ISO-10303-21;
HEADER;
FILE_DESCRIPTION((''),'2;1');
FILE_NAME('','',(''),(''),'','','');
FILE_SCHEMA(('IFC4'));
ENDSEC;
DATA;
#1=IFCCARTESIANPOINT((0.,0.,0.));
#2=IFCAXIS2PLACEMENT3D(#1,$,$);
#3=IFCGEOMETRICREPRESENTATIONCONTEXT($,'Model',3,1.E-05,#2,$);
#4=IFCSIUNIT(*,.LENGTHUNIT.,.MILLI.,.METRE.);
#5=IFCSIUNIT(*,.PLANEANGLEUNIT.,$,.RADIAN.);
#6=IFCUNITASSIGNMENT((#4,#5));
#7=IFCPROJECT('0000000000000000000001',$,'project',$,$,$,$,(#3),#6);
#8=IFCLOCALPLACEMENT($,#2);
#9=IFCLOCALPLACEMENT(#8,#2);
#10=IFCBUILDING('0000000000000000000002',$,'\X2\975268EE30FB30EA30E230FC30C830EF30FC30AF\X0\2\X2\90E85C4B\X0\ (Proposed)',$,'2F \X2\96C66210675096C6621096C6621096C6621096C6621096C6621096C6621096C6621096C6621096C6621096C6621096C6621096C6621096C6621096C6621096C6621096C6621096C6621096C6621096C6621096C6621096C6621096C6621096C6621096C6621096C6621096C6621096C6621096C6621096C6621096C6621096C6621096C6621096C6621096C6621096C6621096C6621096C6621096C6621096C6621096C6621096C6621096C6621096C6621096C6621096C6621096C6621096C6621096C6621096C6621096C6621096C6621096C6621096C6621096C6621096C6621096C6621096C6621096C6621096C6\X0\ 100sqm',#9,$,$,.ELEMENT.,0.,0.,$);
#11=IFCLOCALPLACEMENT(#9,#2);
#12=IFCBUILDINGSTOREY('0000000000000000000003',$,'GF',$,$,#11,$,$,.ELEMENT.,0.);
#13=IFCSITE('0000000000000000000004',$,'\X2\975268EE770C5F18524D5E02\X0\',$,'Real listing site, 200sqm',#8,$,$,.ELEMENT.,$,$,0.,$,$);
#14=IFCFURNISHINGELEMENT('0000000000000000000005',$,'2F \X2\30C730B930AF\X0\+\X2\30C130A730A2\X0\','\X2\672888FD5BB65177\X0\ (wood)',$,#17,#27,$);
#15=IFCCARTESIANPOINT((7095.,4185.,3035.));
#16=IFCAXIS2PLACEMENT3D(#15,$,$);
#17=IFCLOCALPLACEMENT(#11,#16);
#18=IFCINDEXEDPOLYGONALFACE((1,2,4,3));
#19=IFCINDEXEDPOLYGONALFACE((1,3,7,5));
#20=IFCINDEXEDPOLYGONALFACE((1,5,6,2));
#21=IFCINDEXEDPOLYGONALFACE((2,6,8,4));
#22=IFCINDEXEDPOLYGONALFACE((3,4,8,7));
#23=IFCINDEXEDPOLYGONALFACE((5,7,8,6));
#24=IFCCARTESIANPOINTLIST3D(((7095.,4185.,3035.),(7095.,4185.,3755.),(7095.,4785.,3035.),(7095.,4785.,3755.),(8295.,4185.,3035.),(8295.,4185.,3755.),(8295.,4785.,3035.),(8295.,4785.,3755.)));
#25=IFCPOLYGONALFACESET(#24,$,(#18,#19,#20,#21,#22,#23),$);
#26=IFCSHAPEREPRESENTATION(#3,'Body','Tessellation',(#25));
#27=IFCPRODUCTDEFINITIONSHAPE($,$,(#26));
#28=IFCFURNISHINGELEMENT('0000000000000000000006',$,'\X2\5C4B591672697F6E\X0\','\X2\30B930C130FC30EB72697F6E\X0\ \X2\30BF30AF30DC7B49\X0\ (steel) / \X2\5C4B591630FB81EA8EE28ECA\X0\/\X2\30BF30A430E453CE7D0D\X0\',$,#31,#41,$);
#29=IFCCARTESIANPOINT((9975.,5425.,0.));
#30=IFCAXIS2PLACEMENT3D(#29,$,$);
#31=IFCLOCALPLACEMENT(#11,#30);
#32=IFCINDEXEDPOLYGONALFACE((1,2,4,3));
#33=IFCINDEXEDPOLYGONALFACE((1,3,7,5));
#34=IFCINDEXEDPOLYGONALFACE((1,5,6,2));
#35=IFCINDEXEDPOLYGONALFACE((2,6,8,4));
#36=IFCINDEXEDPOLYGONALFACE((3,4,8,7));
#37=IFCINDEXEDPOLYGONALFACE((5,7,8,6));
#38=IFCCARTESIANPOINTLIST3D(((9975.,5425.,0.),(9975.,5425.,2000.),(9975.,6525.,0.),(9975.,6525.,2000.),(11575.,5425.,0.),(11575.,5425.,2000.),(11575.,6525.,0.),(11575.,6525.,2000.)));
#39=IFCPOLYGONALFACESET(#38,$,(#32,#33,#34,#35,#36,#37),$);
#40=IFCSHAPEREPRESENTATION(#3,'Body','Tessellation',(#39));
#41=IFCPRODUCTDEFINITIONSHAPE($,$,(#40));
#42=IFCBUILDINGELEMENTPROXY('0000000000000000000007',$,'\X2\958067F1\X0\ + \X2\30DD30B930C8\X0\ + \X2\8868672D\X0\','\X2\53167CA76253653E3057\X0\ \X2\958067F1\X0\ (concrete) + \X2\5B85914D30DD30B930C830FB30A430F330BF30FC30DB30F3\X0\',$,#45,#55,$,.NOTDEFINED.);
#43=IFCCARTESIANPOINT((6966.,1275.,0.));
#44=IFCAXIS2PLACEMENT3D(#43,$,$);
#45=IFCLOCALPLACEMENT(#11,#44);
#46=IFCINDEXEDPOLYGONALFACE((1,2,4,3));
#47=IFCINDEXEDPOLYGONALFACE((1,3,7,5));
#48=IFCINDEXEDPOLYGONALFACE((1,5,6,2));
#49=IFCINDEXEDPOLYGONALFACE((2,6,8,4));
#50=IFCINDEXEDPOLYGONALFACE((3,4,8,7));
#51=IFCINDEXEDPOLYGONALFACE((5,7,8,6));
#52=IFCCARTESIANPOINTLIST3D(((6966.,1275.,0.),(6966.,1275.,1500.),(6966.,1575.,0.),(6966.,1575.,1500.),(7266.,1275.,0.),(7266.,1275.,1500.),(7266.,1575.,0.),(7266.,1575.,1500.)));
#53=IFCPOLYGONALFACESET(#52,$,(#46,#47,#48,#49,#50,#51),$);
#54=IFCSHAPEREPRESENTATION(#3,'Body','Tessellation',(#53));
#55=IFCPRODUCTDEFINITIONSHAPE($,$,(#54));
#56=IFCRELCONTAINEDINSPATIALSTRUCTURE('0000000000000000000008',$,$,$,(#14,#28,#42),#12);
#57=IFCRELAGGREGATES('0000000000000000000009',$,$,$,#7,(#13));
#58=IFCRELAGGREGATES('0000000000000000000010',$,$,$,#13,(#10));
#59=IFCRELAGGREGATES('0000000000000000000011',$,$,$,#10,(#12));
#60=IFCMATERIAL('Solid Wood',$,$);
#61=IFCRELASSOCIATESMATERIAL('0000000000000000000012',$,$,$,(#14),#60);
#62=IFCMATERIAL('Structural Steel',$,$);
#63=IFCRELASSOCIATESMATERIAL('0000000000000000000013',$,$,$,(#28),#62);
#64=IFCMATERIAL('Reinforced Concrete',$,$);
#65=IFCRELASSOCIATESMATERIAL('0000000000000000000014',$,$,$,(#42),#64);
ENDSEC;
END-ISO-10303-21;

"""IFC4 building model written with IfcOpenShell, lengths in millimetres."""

from ifc_helpers import new_model, si_unit, frame, frame_2d, origin, place, context, project, spatial, rectangle, extrude, material, element, save


model = new_model("IFC4")

# Units and contexts
model_context = context("Model", 3, precision=1e-05, world=origin())
ifc_project = project(units=[si_unit("LENGTHUNIT", "METRE", prefix="MILLI"), si_unit("PLANEANGLEUNIT", "RADIAN")], contexts=[model_context])

# Site, building, storey
site_placement = place(None, origin())
site = spatial("IfcSite", under=ifc_project, at=site_placement, Name="青森県弘前市", ObjectType="Real listing site, 200sqm", CompositionType="ELEMENT", RefElevation=0.0)
building_placement = place(site_placement, origin())
building = spatial("IfcBuilding", under=site, at=building_placement, Name="青森・リモートワーク2部屋 (Proposed)", ObjectType="2F 集成材集成集成集成集成集成集成集成集成集成集成集成集成集成集成集成集成集成集成集成集成集成集成集成集成集成集成集成集成集成集成集成集成集成集成集成集成集成集成集成集成集成集成集成集成集成集成集成集成集成集成集成集成集成集成集成集成集成集成集 100sqm", CompositionType="ELEMENT", ElevationOfRefHeight=0.0, ElevationOfTerrain=0.0)
storey_placement = place(building_placement, origin())
storey = spatial("IfcBuildingStorey", under=building, at=storey_placement, Name="GF", CompositionType="ELEMENT", Elevation=0.0)

# Shared definitions
ifc_material_1 = material(Name="Solid Wood")

# Shared definitions
ifc_material_2 = material(Name="Reinforced Concrete")

# Shared definitions
ifc_material_3 = material(Name="Structural Steel")

# Furnishing elements
furnishing_1_placement = place(storey_placement, frame((7095.0, 4185.0, 3035.0)))
element("IfcFurnishingElement", 1, at=furnishing_1_placement, inside=storey, material=ifc_material_1, Name="2F デスク+チェア", Description="木製家具 (wood)", context=model_context, shape_type="SweptSolid", body=[
    extrude(rectangle(XDim=1200.0, YDim=600.0, at=frame_2d((600.0, 300.0))), frame((7095.0, 4185.0, 3035.0)), (0.0, 0.0, 1.0), 720.0),
])
furnishing_2_placement = place(storey_placement, frame((9975.0, 5425.0, 0.0)))
element("IfcFurnishingElement", 2, at=furnishing_2_placement, inside=storey, material=ifc_material_3, Name="屋外物置", Description="スチール物置 タクボ等 (steel) / 屋外・自転車/タイヤ収納", context=model_context, shape_type="SweptSolid", body=[
    extrude(rectangle(XDim=1600.0, YDim=1100.0, at=frame_2d((800.0, 550.0))), frame((9975.0, 5425.0, 0.0)), (0.0, 0.0, 1.0), 2000.0),
])

# Building element proxy
proxy_placement = place(storey_placement, frame((6966.0, 1275.0, 0.0)))
element("IfcBuildingElementProxy", 3, at=proxy_placement, inside=storey, material=ifc_material_2, Name="門柱 + ポスト + 表札", Description="化粧打放し 門柱 (concrete) + 宅配ポスト・インターホン", PredefinedType="NOTDEFINED", context=model_context, shape_type="SweptSolid", body=[
    extrude(rectangle(XDim=300.0, YDim=300.0, at=frame_2d((150.0, 150.0))), frame((6966.0, 1275.0, 0.0)), (0.0, 0.0, 1.0), 1500.0),
])

save(model, "model.ifc")
